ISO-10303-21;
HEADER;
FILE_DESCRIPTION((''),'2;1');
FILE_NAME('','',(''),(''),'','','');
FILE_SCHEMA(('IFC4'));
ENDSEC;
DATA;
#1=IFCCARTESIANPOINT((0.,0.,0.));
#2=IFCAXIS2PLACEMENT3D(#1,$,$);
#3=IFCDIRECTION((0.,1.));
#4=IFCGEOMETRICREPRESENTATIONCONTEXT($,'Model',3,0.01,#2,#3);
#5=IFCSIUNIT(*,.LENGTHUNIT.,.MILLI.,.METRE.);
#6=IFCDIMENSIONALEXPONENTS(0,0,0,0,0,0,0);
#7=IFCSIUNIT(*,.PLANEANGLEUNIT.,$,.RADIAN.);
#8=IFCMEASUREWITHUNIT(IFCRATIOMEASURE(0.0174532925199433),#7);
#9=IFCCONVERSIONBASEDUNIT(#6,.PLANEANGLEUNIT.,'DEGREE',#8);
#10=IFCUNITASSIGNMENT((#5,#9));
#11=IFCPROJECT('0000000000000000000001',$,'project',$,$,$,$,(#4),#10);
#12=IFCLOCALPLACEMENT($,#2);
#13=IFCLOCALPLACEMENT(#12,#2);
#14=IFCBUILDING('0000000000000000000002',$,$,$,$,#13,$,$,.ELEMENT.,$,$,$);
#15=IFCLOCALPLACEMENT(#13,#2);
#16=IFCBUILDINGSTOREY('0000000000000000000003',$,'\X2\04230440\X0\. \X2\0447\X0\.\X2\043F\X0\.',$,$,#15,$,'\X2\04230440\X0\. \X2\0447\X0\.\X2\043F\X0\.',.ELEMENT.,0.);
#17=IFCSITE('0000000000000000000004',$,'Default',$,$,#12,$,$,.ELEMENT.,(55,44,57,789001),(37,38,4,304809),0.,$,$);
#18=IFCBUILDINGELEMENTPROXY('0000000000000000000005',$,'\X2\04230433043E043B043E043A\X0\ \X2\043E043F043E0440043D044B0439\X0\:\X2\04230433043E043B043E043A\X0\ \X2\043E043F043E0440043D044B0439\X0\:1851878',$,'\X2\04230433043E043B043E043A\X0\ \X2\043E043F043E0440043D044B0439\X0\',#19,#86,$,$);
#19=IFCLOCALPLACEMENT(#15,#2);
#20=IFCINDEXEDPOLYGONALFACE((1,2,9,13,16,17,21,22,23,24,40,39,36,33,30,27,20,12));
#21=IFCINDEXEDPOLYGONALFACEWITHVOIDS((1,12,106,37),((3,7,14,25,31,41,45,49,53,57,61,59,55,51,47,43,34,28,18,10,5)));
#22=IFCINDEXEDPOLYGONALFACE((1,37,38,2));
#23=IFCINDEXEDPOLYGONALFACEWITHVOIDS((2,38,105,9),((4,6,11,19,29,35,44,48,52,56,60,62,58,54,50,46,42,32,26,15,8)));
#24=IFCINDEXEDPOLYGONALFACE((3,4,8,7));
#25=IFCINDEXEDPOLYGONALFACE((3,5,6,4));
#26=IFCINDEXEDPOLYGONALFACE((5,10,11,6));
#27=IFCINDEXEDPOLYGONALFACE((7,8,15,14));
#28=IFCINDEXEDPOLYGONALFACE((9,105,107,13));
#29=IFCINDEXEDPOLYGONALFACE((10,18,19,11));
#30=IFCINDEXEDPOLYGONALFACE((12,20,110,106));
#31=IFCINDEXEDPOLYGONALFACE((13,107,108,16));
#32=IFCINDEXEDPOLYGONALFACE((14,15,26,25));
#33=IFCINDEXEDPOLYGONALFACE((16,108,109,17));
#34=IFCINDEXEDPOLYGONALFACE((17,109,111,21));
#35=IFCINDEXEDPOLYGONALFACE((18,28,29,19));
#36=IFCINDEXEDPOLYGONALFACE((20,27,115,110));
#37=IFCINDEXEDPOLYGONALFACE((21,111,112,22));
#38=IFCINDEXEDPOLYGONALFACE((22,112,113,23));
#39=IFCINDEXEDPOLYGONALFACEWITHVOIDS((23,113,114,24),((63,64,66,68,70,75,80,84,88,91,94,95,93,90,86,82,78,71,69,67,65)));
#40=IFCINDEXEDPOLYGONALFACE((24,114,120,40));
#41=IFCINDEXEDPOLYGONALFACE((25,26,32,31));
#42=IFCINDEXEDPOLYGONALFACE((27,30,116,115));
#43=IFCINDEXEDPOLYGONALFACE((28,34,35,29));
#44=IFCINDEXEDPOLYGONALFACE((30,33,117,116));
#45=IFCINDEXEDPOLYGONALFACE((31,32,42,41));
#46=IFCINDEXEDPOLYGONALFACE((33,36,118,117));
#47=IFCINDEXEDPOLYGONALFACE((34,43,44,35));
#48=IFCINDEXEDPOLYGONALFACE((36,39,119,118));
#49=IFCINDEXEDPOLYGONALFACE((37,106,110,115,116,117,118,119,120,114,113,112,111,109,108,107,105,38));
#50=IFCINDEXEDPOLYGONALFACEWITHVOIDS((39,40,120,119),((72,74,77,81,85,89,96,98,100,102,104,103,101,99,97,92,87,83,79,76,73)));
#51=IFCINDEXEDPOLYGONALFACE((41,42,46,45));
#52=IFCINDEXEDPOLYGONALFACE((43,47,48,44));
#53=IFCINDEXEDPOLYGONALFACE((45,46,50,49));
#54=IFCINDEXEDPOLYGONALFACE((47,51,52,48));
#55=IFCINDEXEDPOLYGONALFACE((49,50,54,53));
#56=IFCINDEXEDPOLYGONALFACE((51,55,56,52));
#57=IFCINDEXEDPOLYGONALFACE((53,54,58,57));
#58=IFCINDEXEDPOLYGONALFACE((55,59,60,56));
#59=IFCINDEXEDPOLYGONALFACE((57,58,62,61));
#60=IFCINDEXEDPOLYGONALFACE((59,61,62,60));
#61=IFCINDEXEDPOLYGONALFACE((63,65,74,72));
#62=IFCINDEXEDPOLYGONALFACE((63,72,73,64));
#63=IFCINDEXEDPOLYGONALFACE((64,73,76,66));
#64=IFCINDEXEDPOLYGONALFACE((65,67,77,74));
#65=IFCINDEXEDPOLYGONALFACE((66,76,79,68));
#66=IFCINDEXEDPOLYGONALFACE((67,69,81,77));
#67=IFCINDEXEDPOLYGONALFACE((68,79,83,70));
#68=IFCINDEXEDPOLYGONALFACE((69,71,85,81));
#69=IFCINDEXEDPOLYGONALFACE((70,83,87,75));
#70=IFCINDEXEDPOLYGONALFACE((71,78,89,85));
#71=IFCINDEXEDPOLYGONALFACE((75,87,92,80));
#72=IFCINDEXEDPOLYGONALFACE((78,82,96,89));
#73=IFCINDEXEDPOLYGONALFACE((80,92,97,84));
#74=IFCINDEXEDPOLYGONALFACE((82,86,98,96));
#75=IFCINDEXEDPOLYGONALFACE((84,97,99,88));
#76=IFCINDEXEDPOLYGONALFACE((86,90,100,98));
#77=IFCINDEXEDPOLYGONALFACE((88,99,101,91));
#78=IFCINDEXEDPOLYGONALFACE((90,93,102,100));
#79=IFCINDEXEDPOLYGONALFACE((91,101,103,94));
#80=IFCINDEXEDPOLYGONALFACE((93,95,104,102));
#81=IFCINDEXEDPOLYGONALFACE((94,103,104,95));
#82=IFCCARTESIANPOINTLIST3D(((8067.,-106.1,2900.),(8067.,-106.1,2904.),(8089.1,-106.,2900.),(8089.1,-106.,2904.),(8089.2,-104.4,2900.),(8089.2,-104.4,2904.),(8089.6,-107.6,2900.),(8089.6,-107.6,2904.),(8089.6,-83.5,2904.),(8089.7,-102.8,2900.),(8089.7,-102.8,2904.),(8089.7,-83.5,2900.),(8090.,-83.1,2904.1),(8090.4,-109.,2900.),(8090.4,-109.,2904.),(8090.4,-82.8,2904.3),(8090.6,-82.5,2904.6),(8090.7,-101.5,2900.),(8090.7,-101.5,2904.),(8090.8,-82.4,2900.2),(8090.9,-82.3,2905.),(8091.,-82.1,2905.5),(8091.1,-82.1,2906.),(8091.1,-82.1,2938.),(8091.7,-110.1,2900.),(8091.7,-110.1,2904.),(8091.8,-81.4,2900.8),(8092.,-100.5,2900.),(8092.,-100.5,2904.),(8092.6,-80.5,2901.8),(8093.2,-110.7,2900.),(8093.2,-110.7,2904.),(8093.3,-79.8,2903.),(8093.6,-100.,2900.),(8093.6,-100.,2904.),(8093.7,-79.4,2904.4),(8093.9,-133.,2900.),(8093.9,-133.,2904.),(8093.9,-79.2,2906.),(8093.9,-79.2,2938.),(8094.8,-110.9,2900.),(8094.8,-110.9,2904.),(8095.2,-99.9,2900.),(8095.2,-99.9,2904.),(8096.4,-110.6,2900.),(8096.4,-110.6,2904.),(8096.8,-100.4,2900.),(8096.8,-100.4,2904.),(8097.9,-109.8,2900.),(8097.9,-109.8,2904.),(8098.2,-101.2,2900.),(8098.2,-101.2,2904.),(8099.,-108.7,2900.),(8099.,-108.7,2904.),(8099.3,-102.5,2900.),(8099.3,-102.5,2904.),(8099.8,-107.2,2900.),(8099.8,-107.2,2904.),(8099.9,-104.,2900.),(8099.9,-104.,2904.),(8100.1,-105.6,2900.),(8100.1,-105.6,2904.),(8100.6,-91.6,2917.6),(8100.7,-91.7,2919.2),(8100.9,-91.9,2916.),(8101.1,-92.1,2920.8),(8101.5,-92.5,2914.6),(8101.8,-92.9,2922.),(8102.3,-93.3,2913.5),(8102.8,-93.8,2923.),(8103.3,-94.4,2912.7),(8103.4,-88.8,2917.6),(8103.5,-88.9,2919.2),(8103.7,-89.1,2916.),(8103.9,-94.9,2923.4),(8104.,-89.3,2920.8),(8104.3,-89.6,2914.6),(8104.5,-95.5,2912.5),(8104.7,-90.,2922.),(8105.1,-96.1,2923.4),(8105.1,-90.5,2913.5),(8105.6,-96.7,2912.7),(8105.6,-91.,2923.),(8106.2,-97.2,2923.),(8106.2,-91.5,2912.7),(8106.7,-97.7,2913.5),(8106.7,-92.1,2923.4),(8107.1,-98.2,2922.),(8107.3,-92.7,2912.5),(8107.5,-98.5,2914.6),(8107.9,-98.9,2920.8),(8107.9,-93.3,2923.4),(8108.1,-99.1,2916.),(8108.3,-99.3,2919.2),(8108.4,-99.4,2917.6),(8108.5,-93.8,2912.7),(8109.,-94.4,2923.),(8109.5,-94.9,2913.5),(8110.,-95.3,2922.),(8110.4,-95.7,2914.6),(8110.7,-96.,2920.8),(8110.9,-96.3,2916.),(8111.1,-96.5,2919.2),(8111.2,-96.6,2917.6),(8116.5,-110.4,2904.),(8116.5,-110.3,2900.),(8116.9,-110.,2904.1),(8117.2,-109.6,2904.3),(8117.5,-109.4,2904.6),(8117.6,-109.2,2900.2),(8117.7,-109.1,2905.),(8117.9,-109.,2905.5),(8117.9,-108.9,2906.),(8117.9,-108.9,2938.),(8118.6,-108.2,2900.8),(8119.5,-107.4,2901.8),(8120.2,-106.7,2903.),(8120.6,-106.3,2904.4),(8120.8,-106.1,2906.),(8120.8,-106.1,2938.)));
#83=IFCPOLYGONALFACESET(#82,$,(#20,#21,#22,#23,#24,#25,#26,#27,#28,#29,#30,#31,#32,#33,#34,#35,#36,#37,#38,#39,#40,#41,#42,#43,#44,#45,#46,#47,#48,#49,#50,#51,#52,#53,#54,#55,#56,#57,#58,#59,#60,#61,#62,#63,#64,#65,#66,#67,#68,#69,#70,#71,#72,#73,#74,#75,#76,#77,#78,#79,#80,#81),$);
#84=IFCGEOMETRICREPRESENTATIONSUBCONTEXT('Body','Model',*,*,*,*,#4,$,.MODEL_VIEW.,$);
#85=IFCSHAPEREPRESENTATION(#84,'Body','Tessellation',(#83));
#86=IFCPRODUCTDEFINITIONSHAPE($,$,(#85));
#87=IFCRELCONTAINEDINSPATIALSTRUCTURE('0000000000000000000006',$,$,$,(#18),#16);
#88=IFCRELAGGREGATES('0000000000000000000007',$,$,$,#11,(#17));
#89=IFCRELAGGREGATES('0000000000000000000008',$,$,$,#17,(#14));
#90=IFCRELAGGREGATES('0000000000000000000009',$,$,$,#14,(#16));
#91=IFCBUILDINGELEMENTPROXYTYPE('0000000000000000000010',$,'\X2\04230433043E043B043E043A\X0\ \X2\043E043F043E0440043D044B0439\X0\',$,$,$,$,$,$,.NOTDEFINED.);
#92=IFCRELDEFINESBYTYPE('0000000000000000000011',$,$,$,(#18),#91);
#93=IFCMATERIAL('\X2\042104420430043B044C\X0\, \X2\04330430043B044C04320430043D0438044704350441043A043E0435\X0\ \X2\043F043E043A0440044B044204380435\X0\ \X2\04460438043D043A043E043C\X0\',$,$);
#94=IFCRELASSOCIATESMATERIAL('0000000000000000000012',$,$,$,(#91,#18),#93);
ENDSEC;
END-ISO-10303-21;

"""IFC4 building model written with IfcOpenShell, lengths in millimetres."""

from ifc_helpers import new_model, entity, si_unit, converted_unit, direction, frame, frame_2d, origin, place, context, subcontext, project, spatial, polyline, circle_curve, parameter, trimmed, segment, composite_curve, circle, outline, extrude, source, transform, mapped, material, type_object, type_shapes, element, save


model = new_model("IFC4")

# Units and contexts
model_context = context("Model", 3, precision=0.01, world=origin(), true_north=direction((0.0, 1.0)))
body_context = subcontext(model_context, "Body", "Model", "MODEL_VIEW")
ifc_project = project(units=[si_unit("LENGTHUNIT", "METRE", prefix="MILLI"), converted_unit("PLANEANGLEUNIT", "DEGREE", entity("IfcRatioMeasure", 0.0174532925199433), si_unit("PLANEANGLEUNIT", "RADIAN"), dimensions=[0, 0, 0, 0, 0, 0, 0])], contexts=[model_context])

# Site, building, storey
site_placement = place(None, origin())
site = spatial("IfcSite", under=ifc_project, at=site_placement, Name="Default", CompositionType="ELEMENT", RefLatitude=(55, 44, 57, 789001), RefLongitude=(37, 38, 4, 304809), RefElevation=0.0)
building_placement = place(site_placement, origin())
building = spatial("IfcBuilding", under=site, at=building_placement, CompositionType="ELEMENT")
storey_placement = place(building_placement, origin())
storey = spatial("IfcBuildingStorey", under=building, at=storey_placement, Name="Ур. ч.п.", LongName="Ур. ч.п.", CompositionType="ELEMENT", Elevation=0.0)

# Building element proxy, openings
ifc_material = material(Name="Сталь, гальваническое покрытие цинком")
building_element_proxy_type_1 = type_object("IfcBuildingElementProxyType", Name="Уголок опорный", material=ifc_material)
shared_shape_1 = source(origin(), body_context, "Body", "SweptSolid", [
    extrude(outline(composite_curve([segment(polyline([(-6.0, -12.0), (26.0, -12.0)]), True, "CONTINUOUS"), segment(polyline([(26.0, -12.0), (26.0, -8.0)]), True, "CONTINUOUS"), segment(polyline([(26.0, -8.0), (-6.0, -8.0)]), True, "CONTINUOUS"), segment(trimmed(circle_curve(frame_2d((-6.0, -6.0), x_axis=(0.0, -1.0)), 2.0), [parameter(270.0)], [parameter(0.0)], True, "PARAMETER"), False, "CONTINUOUS"), segment(polyline([(-8.0, -6.0), (-8.0, 26.0)]), True, "CONTINUOUS"), segment(polyline([(-8.0, 26.0), (-12.0, 26.0)]), True, "CONTINUOUS"), segment(polyline([(-12.0, 26.0), (-12.0, -6.0)]), True, "CONTINUOUS"), segment(trimmed(circle_curve(frame_2d((-6.0, -6.0), x_axis=(0.0, -1.0)), 6.0), [parameter(270.0)], [parameter(360.0)], True, "PARAMETER"), True, "CONTINUOUS")], self_intersect=False)), frame((12.0, -19.0, 12.0), z_axis=(0.0, 1.0, 0.0), x_axis=(0.0, 0.0, 1.0)), (0.0, 0.0, 1.0), 38.0),
])
type_shapes(building_element_proxy_type_1, [shared_shape_1])
proxy_1_placement = place(storey_placement, frame((8107.3, -92.7, 2900.0), z_axis=(0.0, 0.0, 1.0), x_axis=(-0.707107, -0.707107, 0.0)))
proxy_1 = element("IfcBuildingElementProxy", 1, at=proxy_1_placement, inside=storey, type_object=building_element_proxy_type_1, material=ifc_material, Name="Уголок опорный:Уголок опорный:1851878", ObjectType="Уголок опорный", context=body_context, shape_type="MappedRepresentation", body=[
    mapped(shared_shape_1, transform((0.0, 0.0, 0.0), scale=1.0)),
])
opening_1_placement = place(storey_placement, frame((8107.3, -92.7, 2900.0), z_axis=(0.0, 0.0, 1.0), x_axis=(0.0, 1.0, 0.0)))
element("IfcOpeningElement", 2, at=opening_1_placement, cuts=proxy_1, ObjectType="Opening", PredefinedType="OPENING", context=body_context, shape_type="SweptSolid", body=[
    extrude(circle(Radius=5.5, at=frame_2d((0.0, 0.0), x_axis=(1.0, 0.0))), frame((-2.8, 2.8, 18.0), z_axis=(0.707107, -0.707107, 0.0), x_axis=(0.0, 0.0, -1.0)), (0.0, 0.0, 1.0), 4.0),
])
opening_2_placement = place(storey_placement, frame((8107.3, -92.7, 2900.0), z_axis=(0.0, 0.0, 1.0), x_axis=(0.0, 1.0, 0.0)))
element("IfcOpeningElement", 3, at=opening_2_placement, cuts=proxy_1, ObjectType="Opening", PredefinedType="OPENING", context=body_context, shape_type="SweptSolid", body=[
    extrude(circle(Radius=5.5, at=frame_2d((0.0, 0.0), x_axis=(1.0, 0.0))), frame((-12.7, 12.7, 0.0), z_axis=(0.0, 0.0, 1.0), x_axis=(0.707107, 0.707107, 0.0)), (0.0, 0.0, 1.0), 4.0),
])

save(model, "model.ifc")
